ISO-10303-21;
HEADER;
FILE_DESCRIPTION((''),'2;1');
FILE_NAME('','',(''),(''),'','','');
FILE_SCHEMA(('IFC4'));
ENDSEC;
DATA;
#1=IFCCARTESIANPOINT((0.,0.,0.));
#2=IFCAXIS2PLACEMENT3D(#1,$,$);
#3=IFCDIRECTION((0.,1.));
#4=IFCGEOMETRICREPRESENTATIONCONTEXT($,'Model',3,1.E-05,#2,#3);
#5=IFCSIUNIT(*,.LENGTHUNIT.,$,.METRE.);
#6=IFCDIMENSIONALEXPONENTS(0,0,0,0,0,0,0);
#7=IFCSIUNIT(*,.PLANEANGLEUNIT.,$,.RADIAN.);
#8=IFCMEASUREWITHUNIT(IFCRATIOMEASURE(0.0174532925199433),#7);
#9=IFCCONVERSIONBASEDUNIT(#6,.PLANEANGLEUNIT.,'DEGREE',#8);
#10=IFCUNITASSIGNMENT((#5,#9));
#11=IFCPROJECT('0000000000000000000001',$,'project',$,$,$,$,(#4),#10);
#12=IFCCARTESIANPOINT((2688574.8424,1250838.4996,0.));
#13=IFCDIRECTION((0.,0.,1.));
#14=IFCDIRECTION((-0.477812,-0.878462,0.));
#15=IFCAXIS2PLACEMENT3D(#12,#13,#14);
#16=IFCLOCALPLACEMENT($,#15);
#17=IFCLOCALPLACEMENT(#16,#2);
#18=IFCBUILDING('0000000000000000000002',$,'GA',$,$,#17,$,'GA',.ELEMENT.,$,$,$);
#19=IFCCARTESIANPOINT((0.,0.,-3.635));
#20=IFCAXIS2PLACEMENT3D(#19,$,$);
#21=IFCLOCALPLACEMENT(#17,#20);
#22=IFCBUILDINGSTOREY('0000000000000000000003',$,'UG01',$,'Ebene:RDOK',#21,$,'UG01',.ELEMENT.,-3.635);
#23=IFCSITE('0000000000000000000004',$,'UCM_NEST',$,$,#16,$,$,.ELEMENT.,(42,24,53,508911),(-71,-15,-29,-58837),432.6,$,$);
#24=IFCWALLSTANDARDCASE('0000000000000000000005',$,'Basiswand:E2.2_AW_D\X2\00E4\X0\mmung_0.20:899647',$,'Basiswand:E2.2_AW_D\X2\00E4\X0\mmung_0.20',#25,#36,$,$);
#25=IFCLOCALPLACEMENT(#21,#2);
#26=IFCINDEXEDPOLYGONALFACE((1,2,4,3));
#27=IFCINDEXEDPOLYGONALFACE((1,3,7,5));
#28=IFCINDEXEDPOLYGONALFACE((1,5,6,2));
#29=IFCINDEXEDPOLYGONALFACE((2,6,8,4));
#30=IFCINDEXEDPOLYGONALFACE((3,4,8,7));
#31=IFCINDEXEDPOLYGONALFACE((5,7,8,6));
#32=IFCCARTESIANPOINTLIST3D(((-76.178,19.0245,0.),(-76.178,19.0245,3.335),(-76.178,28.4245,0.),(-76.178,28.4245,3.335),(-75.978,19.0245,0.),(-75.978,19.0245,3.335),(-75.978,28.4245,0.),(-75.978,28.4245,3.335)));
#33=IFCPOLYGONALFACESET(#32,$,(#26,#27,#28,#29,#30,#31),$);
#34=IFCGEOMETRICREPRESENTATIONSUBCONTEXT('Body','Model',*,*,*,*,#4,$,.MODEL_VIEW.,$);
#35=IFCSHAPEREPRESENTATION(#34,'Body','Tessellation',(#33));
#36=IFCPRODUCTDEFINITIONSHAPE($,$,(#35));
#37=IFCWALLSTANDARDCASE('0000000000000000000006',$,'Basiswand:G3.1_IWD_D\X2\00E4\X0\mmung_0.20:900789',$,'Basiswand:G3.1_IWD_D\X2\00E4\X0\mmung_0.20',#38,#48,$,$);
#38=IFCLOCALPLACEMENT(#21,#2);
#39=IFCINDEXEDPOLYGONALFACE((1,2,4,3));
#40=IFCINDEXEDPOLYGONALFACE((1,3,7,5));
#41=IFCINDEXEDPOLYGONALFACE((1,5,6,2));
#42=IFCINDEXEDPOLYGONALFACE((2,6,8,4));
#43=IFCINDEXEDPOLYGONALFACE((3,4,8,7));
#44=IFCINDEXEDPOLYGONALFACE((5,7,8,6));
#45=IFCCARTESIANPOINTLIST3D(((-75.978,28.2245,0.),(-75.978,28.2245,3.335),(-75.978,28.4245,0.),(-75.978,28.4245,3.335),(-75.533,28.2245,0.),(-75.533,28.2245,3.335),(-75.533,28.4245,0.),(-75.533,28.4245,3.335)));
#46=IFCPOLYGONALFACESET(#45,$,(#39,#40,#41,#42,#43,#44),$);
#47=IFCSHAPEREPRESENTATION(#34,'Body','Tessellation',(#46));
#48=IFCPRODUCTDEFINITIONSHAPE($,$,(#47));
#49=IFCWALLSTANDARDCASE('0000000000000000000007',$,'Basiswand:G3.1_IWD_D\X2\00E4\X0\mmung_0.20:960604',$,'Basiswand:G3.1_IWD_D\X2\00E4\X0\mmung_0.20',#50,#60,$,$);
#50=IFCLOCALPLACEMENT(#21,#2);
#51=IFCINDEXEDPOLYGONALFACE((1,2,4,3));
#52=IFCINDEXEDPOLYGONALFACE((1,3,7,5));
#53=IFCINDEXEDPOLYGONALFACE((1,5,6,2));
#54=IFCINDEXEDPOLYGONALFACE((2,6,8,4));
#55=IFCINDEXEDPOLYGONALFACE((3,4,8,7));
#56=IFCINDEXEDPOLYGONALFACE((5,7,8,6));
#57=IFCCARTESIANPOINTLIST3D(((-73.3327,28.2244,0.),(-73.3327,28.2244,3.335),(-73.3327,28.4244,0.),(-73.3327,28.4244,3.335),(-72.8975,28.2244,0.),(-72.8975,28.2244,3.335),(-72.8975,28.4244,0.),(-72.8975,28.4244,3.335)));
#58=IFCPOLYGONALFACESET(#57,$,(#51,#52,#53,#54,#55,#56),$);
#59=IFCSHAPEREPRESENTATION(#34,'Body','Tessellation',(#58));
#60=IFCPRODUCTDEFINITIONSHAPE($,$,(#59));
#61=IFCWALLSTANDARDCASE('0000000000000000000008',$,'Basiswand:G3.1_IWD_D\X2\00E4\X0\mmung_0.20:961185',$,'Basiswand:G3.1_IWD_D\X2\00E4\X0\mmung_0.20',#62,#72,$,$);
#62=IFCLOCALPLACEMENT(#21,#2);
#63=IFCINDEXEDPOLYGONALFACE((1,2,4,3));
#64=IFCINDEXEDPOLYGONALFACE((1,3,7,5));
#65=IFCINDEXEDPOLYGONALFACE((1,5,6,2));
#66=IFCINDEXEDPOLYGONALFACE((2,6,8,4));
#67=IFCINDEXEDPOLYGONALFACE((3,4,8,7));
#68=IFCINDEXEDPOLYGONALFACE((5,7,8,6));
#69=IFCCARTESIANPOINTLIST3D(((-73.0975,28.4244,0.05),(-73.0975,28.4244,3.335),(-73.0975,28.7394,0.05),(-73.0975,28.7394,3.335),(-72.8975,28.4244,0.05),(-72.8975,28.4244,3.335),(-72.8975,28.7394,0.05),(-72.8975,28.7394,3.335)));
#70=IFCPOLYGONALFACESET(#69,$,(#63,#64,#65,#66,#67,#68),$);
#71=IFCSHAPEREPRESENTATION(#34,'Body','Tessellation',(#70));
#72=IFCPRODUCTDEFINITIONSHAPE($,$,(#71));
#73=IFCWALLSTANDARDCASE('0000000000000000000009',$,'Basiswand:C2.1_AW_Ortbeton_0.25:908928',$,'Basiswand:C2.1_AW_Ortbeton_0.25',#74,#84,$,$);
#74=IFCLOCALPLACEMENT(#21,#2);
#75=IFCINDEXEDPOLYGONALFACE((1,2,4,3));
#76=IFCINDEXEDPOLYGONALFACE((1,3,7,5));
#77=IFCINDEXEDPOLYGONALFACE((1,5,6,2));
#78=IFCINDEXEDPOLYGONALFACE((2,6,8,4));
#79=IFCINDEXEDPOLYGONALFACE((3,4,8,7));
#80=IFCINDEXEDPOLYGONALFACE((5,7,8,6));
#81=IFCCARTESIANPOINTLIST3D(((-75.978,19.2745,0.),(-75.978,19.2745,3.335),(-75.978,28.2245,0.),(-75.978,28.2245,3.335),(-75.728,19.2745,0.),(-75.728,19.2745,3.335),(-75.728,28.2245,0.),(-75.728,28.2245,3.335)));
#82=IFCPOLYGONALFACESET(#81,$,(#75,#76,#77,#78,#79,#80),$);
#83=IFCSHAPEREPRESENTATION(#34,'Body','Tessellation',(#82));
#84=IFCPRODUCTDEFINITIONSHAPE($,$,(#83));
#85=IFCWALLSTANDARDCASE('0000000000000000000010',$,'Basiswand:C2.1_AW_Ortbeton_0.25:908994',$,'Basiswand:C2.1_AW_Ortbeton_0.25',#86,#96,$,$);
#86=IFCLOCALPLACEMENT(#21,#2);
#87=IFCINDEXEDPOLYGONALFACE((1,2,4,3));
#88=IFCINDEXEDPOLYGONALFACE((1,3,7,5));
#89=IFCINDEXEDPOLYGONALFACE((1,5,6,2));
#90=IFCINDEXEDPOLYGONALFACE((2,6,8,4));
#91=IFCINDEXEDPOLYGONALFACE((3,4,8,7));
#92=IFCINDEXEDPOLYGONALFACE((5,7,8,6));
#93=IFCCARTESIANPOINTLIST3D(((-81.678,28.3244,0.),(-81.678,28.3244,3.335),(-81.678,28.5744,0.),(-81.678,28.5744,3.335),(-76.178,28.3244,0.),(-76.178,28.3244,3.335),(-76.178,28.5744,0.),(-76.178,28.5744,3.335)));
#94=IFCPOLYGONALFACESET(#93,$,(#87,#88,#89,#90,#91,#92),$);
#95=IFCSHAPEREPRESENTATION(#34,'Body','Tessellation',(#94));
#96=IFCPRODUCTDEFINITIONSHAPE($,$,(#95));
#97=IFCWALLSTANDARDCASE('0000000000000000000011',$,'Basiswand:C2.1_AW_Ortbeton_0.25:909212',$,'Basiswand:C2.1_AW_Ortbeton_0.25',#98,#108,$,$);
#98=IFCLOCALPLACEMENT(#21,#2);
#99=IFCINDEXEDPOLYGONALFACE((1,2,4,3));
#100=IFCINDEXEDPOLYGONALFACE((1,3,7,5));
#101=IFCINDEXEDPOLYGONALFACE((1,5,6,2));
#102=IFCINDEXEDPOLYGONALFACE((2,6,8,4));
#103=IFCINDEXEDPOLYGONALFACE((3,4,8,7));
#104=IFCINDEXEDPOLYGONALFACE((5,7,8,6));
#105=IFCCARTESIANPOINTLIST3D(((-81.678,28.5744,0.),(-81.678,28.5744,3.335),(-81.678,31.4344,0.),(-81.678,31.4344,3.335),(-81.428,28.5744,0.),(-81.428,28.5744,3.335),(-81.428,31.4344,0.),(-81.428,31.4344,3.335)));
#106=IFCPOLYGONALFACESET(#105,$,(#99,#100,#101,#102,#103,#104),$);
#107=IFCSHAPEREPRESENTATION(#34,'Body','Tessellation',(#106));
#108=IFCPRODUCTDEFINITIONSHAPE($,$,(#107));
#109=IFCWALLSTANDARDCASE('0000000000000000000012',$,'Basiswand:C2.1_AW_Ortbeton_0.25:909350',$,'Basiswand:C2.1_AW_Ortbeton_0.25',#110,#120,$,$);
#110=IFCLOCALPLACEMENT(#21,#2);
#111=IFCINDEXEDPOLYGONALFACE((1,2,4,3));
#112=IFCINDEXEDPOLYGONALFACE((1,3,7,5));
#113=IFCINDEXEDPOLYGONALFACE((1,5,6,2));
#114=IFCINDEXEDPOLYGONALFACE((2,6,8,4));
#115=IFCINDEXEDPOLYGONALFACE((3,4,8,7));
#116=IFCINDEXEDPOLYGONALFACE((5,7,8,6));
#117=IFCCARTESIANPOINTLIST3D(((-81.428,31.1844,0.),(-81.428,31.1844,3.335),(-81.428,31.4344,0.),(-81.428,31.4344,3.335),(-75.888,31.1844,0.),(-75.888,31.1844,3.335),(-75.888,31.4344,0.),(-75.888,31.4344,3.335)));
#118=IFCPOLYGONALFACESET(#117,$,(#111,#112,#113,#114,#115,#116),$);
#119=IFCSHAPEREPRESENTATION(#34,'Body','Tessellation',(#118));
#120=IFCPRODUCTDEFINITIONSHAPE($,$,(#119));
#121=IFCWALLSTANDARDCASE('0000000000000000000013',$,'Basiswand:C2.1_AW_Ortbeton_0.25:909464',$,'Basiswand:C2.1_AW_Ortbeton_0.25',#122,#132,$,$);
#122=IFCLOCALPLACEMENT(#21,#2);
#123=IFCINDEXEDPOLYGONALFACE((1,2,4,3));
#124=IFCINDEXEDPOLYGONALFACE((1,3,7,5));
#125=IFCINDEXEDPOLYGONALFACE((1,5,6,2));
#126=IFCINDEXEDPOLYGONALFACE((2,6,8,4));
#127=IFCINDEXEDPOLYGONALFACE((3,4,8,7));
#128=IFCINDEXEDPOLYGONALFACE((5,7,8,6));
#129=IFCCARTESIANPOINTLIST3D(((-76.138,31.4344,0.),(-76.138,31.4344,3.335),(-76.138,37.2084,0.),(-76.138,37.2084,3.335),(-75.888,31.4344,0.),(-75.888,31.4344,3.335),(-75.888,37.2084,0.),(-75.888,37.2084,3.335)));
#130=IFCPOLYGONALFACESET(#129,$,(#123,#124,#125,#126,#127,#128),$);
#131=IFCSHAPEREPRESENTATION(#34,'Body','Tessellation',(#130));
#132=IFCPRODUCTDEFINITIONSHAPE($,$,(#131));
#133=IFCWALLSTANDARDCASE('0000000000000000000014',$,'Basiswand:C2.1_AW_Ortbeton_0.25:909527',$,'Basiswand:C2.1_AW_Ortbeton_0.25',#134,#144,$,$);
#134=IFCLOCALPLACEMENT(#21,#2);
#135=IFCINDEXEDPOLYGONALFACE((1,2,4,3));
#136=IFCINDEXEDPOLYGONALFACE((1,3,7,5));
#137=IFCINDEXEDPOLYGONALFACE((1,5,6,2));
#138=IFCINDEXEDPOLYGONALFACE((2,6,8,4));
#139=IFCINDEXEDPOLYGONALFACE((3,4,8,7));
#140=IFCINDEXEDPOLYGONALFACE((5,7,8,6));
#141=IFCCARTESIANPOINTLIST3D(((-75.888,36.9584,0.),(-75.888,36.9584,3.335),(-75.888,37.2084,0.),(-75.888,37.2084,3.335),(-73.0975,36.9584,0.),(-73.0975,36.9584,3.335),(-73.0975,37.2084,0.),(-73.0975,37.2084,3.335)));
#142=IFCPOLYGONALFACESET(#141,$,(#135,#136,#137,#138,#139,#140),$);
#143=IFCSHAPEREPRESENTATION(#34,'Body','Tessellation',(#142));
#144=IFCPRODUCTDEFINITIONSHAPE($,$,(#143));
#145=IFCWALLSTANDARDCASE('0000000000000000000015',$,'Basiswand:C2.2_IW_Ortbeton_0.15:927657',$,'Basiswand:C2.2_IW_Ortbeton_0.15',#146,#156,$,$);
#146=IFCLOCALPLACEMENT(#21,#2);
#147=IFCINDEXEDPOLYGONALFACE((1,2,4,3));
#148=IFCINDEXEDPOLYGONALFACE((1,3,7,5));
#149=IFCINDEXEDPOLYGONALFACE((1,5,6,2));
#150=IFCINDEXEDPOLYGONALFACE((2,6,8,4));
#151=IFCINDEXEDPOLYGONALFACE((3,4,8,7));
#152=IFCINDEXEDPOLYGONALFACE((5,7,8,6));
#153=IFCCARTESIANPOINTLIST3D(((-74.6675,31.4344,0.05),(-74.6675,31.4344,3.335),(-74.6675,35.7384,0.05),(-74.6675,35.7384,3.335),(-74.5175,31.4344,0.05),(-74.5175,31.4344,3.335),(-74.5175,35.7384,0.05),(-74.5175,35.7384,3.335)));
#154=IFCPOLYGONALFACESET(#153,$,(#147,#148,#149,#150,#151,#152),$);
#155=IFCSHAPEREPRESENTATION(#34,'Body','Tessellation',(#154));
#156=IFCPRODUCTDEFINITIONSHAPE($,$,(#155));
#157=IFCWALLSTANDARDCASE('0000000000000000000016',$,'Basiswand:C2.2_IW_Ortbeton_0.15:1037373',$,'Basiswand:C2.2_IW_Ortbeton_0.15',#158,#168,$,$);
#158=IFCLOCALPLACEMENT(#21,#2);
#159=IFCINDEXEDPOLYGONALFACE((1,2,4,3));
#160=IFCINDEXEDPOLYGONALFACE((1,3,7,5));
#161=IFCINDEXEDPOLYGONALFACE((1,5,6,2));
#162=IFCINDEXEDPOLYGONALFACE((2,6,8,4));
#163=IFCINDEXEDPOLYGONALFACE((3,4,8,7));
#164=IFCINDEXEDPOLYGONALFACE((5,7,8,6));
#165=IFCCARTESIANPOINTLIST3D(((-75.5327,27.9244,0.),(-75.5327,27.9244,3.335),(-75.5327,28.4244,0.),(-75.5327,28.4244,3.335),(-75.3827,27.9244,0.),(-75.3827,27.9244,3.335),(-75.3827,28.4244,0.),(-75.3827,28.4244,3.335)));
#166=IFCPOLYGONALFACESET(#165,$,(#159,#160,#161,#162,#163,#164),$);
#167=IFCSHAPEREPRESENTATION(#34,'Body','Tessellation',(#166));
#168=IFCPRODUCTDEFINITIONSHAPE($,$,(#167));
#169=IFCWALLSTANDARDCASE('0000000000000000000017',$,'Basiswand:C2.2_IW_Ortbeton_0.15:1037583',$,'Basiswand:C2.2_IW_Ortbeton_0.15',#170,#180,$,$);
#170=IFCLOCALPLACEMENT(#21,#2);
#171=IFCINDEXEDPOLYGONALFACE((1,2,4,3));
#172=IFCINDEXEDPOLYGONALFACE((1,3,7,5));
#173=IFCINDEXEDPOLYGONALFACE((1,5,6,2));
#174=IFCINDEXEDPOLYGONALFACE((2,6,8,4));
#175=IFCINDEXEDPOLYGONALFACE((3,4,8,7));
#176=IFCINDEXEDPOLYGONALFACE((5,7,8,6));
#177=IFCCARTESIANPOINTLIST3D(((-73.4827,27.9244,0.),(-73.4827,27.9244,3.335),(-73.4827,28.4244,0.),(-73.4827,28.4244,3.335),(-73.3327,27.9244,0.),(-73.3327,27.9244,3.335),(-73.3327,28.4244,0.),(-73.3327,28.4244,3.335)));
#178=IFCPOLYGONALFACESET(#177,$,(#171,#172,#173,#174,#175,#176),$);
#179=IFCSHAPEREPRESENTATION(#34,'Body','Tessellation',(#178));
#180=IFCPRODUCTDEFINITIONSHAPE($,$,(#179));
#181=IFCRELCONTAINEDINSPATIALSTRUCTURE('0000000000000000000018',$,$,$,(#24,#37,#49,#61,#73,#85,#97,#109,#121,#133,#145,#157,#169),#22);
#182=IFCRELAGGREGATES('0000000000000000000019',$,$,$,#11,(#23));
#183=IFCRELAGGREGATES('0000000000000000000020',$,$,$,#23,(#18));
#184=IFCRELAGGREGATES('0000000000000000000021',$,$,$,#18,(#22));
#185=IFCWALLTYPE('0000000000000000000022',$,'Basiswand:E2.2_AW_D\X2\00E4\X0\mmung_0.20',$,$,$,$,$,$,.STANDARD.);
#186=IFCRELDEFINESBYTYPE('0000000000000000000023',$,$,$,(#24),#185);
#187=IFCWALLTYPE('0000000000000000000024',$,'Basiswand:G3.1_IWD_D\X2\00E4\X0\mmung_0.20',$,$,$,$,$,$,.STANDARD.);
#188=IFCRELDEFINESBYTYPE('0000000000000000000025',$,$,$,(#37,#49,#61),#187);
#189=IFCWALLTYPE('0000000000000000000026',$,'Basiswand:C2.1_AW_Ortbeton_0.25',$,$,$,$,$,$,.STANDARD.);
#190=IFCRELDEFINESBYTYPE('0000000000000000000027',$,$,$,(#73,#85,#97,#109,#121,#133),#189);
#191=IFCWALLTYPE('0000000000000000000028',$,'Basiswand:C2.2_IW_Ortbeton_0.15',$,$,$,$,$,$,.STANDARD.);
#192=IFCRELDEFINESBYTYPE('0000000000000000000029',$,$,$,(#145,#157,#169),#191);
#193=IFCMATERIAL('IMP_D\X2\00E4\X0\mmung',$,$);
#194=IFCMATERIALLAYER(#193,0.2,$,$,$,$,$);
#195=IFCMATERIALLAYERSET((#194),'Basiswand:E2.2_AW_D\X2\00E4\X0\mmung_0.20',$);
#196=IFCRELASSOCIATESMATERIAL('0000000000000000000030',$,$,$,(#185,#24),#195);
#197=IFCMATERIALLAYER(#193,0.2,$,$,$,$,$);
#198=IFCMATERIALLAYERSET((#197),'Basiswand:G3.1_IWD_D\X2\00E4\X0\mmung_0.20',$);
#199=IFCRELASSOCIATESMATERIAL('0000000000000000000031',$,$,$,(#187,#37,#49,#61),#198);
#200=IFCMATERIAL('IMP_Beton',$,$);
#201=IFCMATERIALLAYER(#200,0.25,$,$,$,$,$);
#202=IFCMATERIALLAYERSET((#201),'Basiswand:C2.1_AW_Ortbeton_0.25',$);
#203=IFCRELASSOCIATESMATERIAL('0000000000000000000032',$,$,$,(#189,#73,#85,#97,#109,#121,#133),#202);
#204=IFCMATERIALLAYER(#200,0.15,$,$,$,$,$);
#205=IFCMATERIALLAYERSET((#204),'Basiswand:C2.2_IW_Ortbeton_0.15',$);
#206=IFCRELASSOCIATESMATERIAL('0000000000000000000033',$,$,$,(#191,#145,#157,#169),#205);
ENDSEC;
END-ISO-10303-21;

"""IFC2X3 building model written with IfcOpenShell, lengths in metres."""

from ifc_helpers import new_model, entity, si_unit, converted_unit, direction, frame, frame_2d, origin, place, context, subcontext, project, spatial, polyline, rectangle, extrude, clip, bounded_halfspace, material, layer, layer_set, layer_usage, type_object, element, save


model = new_model("IFC2X3")

# Units and contexts
model_context = context("Model", 3, precision=1e-05, world=origin(), true_north=direction((0.0, 1.0)))
body_context = subcontext(model_context, "Body", "Model", "MODEL_VIEW")
ifc_project = project(units=[si_unit("LENGTHUNIT", "METRE"), converted_unit("PLANEANGLEUNIT", "DEGREE", entity("IfcRatioMeasure", 0.0174532925199433), si_unit("PLANEANGLEUNIT", "RADIAN"), dimensions=[0, 0, 0, 0, 0, 0, 0])], contexts=[model_context])

# Site, building, storey
site_placement = place(None, frame((2688574.8424, 1250838.4996, 0.0), z_axis=(0.0, 0.0, 1.0), x_axis=(-0.477812, -0.878462, 0.0)))
site = spatial("IfcSite", under=ifc_project, at=site_placement, Name="UCM_NEST", CompositionType="ELEMENT", RefLatitude=(42, 24, 53, 508911), RefLongitude=(-71, -15, -29, -58837), RefElevation=432.6)
building_placement = place(site_placement, origin())
building = spatial("IfcBuilding", under=site, at=building_placement, Name="GA", LongName="GA", CompositionType="ELEMENT")
storey_placement = place(building_placement, frame((0.0, 0.0, -3.635)))
storey = spatial("IfcBuildingStorey", under=building, at=storey_placement, Name="UG01", ObjectType="Ebene:RDOK", LongName="UG01", CompositionType="ELEMENT", Elevation=-3.635)

# Walls
ifc_material_1 = material(Name="IMP_Dämmung")
ifc_layer_1 = layer(ifc_material_1, 0.2)
ifc_layer_set_1 = layer_set([ifc_layer_1], Name="Basiswand:E2.2_AW_Dämmung_0.20")
ifc_layer_usage_1 = layer_usage(ifc_layer_set_1, "AXIS2", "NEGATIVE", 0.1)
wall_type_1 = type_object("IfcWallType", Name="Basiswand:E2.2_AW_Dämmung_0.20", PredefinedType="STANDARD", material=ifc_layer_set_1)
wall_1_placement = place(storey_placement, frame((-76.078, 19.0245, 0.0), z_axis=(0.0, 0.0, 1.0), x_axis=(0.0, 1.0, 0.0)))
element("IfcWallStandardCase", 1, at=wall_1_placement, inside=storey, type_object=wall_type_1, material=ifc_layer_usage_1, Name="Basiswand:E2.2_AW_Dämmung_0.20:899647", ObjectType="Basiswand:E2.2_AW_Dämmung_0.20", context=body_context, shape_type="SweptSolid", body=[
    extrude(rectangle(XDim=9.4, YDim=0.2, at=frame_2d((4.7, 0.0), x_axis=(-1.0, 0.0))), origin(), (0.0, 0.0, 1.0), 3.335),
])
ifc_layer_2 = layer(ifc_material_1, 0.2)
ifc_layer_set_2 = layer_set([ifc_layer_2], Name="Basiswand:G3.1_IWD_Dämmung_0.20")
ifc_layer_usage_2 = layer_usage(ifc_layer_set_2, "AXIS2", "NEGATIVE", 0.1)
wall_type_2 = type_object("IfcWallType", Name="Basiswand:G3.1_IWD_Dämmung_0.20", PredefinedType="STANDARD", material=ifc_layer_set_2)
wall_2_placement = place(storey_placement, frame((-75.978, 28.3245, 0.0)))
element("IfcWallStandardCase", 2, at=wall_2_placement, inside=storey, type_object=wall_type_2, material=ifc_layer_usage_2, Name="Basiswand:G3.1_IWD_Dämmung_0.20:900789", ObjectType="Basiswand:G3.1_IWD_Dämmung_0.20", context=body_context, shape_type="SweptSolid", body=[
    extrude(rectangle(XDim=0.445, YDim=0.2, at=frame_2d((0.2225, 0.0), x_axis=(-1.0, 0.0))), origin(), (0.0, 0.0, 1.0), 3.335),
])
ifc_layer_usage_3 = layer_usage(ifc_layer_set_2, "AXIS2", "NEGATIVE", 0.1)
wall_3_placement = place(storey_placement, frame((-73.3327, 28.3244, 0.0)))
element("IfcWallStandardCase", 3, at=wall_3_placement, inside=storey, type_object=wall_type_2, material=ifc_layer_usage_3, Name="Basiswand:G3.1_IWD_Dämmung_0.20:960604", ObjectType="Basiswand:G3.1_IWD_Dämmung_0.20", context=body_context, shape_type="SweptSolid", body=[
    extrude(rectangle(XDim=0.4353, YDim=0.2, at=frame_2d((0.2176, 0.0), x_axis=(-1.0, 0.0))), origin(), (0.0, 0.0, 1.0), 3.335),
])
ifc_layer_usage_4 = layer_usage(ifc_layer_set_2, "AXIS2", "NEGATIVE", 0.1)
wall_4_placement = place(storey_placement, frame((-72.9975, 28.7394, 0.05), z_axis=(0.0, 0.0, 1.0), x_axis=(0.0, -1.0, 0.0)))
element("IfcWallStandardCase", 4, at=wall_4_placement, inside=storey, type_object=wall_type_2, material=ifc_layer_usage_4, Name="Basiswand:G3.1_IWD_Dämmung_0.20:961185", ObjectType="Basiswand:G3.1_IWD_Dämmung_0.20", context=body_context, shape_type="Clipping", body=[
    clip(extrude(rectangle(XDim=0.315, YDim=0.2, at=frame_2d((0.1575, 0.0), x_axis=(-1.0, 0.0))), origin(), (0.0, 0.0, 1.0), 3.285), bounded_halfspace(frame((0.315, -0.1, 0.0), z_axis=(0.0, 0.0, 1.0), x_axis=(-1.0, 0.0, 0.0)), True, frame((0.315, -0.1, 0.0), z_axis=(0.0, 0.0, 1.0), x_axis=(-1.0, 0.0, 0.0)), polyline([(0.0, 0.0), (0.0, -0.2), (0.315, -0.2), (0.315, 0.0), (0.0, 0.0)]))),
])
ifc_material_2 = material(Name="IMP_Beton")
ifc_layer_3 = layer(ifc_material_2, 0.25)
ifc_layer_set_3 = layer_set([ifc_layer_3], Name="Basiswand:C2.1_AW_Ortbeton_0.25")
ifc_layer_usage_5 = layer_usage(ifc_layer_set_3, "AXIS2", "NEGATIVE", 0.125)
wall_type_3 = type_object("IfcWallType", Name="Basiswand:C2.1_AW_Ortbeton_0.25", PredefinedType="STANDARD", material=ifc_layer_set_3)
wall_5_placement = place(storey_placement, frame((-75.853, 19.2745, 0.0), z_axis=(0.0, 0.0, 1.0), x_axis=(0.0, 1.0, 0.0)))
element("IfcWallStandardCase", 5, at=wall_5_placement, inside=storey, type_object=wall_type_3, material=ifc_layer_usage_5, Name="Basiswand:C2.1_AW_Ortbeton_0.25:908928", ObjectType="Basiswand:C2.1_AW_Ortbeton_0.25", context=body_context, shape_type="SweptSolid", body=[
    extrude(rectangle(XDim=8.95, YDim=0.25, at=frame_2d((4.475, 0.0), x_axis=(-1.0, 0.0))), origin(), (0.0, 0.0, 1.0), 3.335),
])
ifc_layer_usage_6 = layer_usage(ifc_layer_set_3, "AXIS2", "NEGATIVE", 0.125)
wall_6_placement = place(storey_placement, frame((-76.178, 28.4494, 0.0), z_axis=(0.0, 0.0, 1.0), x_axis=(-1.0, 0.0, 0.0)))
element("IfcWallStandardCase", 6, at=wall_6_placement, inside=storey, type_object=wall_type_3, material=ifc_layer_usage_6, Name="Basiswand:C2.1_AW_Ortbeton_0.25:908994", ObjectType="Basiswand:C2.1_AW_Ortbeton_0.25", context=body_context, shape_type="SweptSolid", body=[
    extrude(rectangle(XDim=5.5, YDim=0.25, at=frame_2d((2.75, 0.0), x_axis=(-1.0, 0.0))), origin(), (0.0, 0.0, 1.0), 3.335),
])
ifc_layer_usage_7 = layer_usage(ifc_layer_set_3, "AXIS2", "NEGATIVE", 0.125)
wall_7_placement = place(storey_placement, frame((-81.553, 28.5744, 0.0), z_axis=(0.0, 0.0, 1.0), x_axis=(0.0, 1.0, 0.0)))
element("IfcWallStandardCase", 7, at=wall_7_placement, inside=storey, type_object=wall_type_3, material=ifc_layer_usage_7, Name="Basiswand:C2.1_AW_Ortbeton_0.25:909212", ObjectType="Basiswand:C2.1_AW_Ortbeton_0.25", context=body_context, shape_type="SweptSolid", body=[
    extrude(rectangle(XDim=2.86, YDim=0.25, at=frame_2d((1.43, 0.0), x_axis=(-1.0, 0.0))), origin(), (0.0, 0.0, 1.0), 3.335),
])
ifc_layer_usage_8 = layer_usage(ifc_layer_set_3, "AXIS2", "NEGATIVE", 0.125)
wall_8_placement = place(storey_placement, frame((-81.428, 31.3094, 0.0)))
element("IfcWallStandardCase", 8, at=wall_8_placement, inside=storey, type_object=wall_type_3, material=ifc_layer_usage_8, Name="Basiswand:C2.1_AW_Ortbeton_0.25:909350", ObjectType="Basiswand:C2.1_AW_Ortbeton_0.25", context=body_context, shape_type="SweptSolid", body=[
    extrude(rectangle(XDim=5.54, YDim=0.25, at=frame_2d((2.77, 0.0), x_axis=(-1.0, 0.0))), origin(), (0.0, 0.0, 1.0), 3.335),
])
ifc_layer_usage_9 = layer_usage(ifc_layer_set_3, "AXIS2", "NEGATIVE", 0.125)
wall_9_placement = place(storey_placement, frame((-76.013, 31.4344, 0.0), z_axis=(0.0, 0.0, 1.0), x_axis=(0.0, 1.0, 0.0)))
element("IfcWallStandardCase", 9, at=wall_9_placement, inside=storey, type_object=wall_type_3, material=ifc_layer_usage_9, Name="Basiswand:C2.1_AW_Ortbeton_0.25:909464", ObjectType="Basiswand:C2.1_AW_Ortbeton_0.25", context=body_context, shape_type="SweptSolid", body=[
    extrude(rectangle(XDim=5.774, YDim=0.25, at=frame_2d((2.887, 0.0), x_axis=(-1.0, 0.0))), origin(), (0.0, 0.0, 1.0), 3.335),
])
ifc_layer_usage_10 = layer_usage(ifc_layer_set_3, "AXIS2", "NEGATIVE", 0.125)
wall_10_placement = place(storey_placement, frame((-75.888, 37.0834, 0.0)))
element("IfcWallStandardCase", 10, at=wall_10_placement, inside=storey, type_object=wall_type_3, material=ifc_layer_usage_10, Name="Basiswand:C2.1_AW_Ortbeton_0.25:909527", ObjectType="Basiswand:C2.1_AW_Ortbeton_0.25", context=body_context, shape_type="SweptSolid", body=[
    extrude(rectangle(XDim=2.7905, YDim=0.25, at=frame_2d((1.3953, 0.0), x_axis=(-1.0, 0.0))), origin(), (0.0, 0.0, 1.0), 3.335),
])

# Shared definitions
ifc_layer_4 = layer(ifc_material_2, 0.15)
ifc_layer_set_4 = layer_set([ifc_layer_4], Name="Basiswand:C2.2_IW_Ortbeton_0.15")
wall_type_4 = type_object("IfcWallType", Name="Basiswand:C2.2_IW_Ortbeton_0.15", PredefinedType="STANDARD", material=ifc_layer_set_4)

# Walls
ifc_layer_usage_11 = layer_usage(ifc_layer_set_4, "AXIS2", "NEGATIVE", 0.075)
wall_11_placement = place(storey_placement, frame((-74.5925, 31.4344, 0.05), z_axis=(0.0, 0.0, 1.0), x_axis=(0.0, 1.0, 0.0)))
element("IfcWallStandardCase", 11, at=wall_11_placement, inside=storey, type_object=wall_type_4, material=ifc_layer_usage_11, Name="Basiswand:C2.2_IW_Ortbeton_0.15:927657", ObjectType="Basiswand:C2.2_IW_Ortbeton_0.15", context=body_context, shape_type="Clipping", body=[
    clip(extrude(rectangle(XDim=4.304, YDim=0.15, at=frame_2d((2.152, 0.0), x_axis=(-1.0, 0.0))), origin(), (0.0, 0.0, 1.0), 3.285), bounded_halfspace(frame((4.304, -0.075, 0.0)), True, frame((4.304, -0.075, 0.0)), polyline([(0.0, 0.0), (0.0, 0.15), (-4.304, 0.15), (-4.304, 0.0), (0.0, 0.0)]))),
])
ifc_layer_usage_12 = layer_usage(ifc_layer_set_4, "AXIS2", "NEGATIVE", 0.075)
wall_12_placement = place(storey_placement, frame((-75.4577, 27.9244, 0.0), z_axis=(0.0, 0.0, 1.0), x_axis=(0.0, 1.0, 0.0)))
element("IfcWallStandardCase", 12, at=wall_12_placement, inside=storey, type_object=wall_type_4, material=ifc_layer_usage_12, Name="Basiswand:C2.2_IW_Ortbeton_0.15:1037373", ObjectType="Basiswand:C2.2_IW_Ortbeton_0.15", context=body_context, shape_type="SweptSolid", body=[
    extrude(rectangle(XDim=0.5, YDim=0.15, at=frame_2d((0.25, 0.0), x_axis=(-1.0, 0.0))), origin(), (0.0, 0.0, 1.0), 3.335),
])
ifc_layer_usage_13 = layer_usage(ifc_layer_set_4, "AXIS2", "NEGATIVE", 0.075)
wall_13_placement = place(storey_placement, frame((-73.4077, 28.4244, 0.0), z_axis=(0.0, 0.0, 1.0), x_axis=(0.0, -1.0, 0.0)))
element("IfcWallStandardCase", 13, at=wall_13_placement, inside=storey, type_object=wall_type_4, material=ifc_layer_usage_13, Name="Basiswand:C2.2_IW_Ortbeton_0.15:1037583", ObjectType="Basiswand:C2.2_IW_Ortbeton_0.15", context=body_context, shape_type="SweptSolid", body=[
    extrude(rectangle(XDim=0.5, YDim=0.15, at=frame_2d((0.25, 0.0), x_axis=(-1.0, 0.0))), origin(), (0.0, 0.0, 1.0), 3.335),
])

save(model, "model.ifc")
